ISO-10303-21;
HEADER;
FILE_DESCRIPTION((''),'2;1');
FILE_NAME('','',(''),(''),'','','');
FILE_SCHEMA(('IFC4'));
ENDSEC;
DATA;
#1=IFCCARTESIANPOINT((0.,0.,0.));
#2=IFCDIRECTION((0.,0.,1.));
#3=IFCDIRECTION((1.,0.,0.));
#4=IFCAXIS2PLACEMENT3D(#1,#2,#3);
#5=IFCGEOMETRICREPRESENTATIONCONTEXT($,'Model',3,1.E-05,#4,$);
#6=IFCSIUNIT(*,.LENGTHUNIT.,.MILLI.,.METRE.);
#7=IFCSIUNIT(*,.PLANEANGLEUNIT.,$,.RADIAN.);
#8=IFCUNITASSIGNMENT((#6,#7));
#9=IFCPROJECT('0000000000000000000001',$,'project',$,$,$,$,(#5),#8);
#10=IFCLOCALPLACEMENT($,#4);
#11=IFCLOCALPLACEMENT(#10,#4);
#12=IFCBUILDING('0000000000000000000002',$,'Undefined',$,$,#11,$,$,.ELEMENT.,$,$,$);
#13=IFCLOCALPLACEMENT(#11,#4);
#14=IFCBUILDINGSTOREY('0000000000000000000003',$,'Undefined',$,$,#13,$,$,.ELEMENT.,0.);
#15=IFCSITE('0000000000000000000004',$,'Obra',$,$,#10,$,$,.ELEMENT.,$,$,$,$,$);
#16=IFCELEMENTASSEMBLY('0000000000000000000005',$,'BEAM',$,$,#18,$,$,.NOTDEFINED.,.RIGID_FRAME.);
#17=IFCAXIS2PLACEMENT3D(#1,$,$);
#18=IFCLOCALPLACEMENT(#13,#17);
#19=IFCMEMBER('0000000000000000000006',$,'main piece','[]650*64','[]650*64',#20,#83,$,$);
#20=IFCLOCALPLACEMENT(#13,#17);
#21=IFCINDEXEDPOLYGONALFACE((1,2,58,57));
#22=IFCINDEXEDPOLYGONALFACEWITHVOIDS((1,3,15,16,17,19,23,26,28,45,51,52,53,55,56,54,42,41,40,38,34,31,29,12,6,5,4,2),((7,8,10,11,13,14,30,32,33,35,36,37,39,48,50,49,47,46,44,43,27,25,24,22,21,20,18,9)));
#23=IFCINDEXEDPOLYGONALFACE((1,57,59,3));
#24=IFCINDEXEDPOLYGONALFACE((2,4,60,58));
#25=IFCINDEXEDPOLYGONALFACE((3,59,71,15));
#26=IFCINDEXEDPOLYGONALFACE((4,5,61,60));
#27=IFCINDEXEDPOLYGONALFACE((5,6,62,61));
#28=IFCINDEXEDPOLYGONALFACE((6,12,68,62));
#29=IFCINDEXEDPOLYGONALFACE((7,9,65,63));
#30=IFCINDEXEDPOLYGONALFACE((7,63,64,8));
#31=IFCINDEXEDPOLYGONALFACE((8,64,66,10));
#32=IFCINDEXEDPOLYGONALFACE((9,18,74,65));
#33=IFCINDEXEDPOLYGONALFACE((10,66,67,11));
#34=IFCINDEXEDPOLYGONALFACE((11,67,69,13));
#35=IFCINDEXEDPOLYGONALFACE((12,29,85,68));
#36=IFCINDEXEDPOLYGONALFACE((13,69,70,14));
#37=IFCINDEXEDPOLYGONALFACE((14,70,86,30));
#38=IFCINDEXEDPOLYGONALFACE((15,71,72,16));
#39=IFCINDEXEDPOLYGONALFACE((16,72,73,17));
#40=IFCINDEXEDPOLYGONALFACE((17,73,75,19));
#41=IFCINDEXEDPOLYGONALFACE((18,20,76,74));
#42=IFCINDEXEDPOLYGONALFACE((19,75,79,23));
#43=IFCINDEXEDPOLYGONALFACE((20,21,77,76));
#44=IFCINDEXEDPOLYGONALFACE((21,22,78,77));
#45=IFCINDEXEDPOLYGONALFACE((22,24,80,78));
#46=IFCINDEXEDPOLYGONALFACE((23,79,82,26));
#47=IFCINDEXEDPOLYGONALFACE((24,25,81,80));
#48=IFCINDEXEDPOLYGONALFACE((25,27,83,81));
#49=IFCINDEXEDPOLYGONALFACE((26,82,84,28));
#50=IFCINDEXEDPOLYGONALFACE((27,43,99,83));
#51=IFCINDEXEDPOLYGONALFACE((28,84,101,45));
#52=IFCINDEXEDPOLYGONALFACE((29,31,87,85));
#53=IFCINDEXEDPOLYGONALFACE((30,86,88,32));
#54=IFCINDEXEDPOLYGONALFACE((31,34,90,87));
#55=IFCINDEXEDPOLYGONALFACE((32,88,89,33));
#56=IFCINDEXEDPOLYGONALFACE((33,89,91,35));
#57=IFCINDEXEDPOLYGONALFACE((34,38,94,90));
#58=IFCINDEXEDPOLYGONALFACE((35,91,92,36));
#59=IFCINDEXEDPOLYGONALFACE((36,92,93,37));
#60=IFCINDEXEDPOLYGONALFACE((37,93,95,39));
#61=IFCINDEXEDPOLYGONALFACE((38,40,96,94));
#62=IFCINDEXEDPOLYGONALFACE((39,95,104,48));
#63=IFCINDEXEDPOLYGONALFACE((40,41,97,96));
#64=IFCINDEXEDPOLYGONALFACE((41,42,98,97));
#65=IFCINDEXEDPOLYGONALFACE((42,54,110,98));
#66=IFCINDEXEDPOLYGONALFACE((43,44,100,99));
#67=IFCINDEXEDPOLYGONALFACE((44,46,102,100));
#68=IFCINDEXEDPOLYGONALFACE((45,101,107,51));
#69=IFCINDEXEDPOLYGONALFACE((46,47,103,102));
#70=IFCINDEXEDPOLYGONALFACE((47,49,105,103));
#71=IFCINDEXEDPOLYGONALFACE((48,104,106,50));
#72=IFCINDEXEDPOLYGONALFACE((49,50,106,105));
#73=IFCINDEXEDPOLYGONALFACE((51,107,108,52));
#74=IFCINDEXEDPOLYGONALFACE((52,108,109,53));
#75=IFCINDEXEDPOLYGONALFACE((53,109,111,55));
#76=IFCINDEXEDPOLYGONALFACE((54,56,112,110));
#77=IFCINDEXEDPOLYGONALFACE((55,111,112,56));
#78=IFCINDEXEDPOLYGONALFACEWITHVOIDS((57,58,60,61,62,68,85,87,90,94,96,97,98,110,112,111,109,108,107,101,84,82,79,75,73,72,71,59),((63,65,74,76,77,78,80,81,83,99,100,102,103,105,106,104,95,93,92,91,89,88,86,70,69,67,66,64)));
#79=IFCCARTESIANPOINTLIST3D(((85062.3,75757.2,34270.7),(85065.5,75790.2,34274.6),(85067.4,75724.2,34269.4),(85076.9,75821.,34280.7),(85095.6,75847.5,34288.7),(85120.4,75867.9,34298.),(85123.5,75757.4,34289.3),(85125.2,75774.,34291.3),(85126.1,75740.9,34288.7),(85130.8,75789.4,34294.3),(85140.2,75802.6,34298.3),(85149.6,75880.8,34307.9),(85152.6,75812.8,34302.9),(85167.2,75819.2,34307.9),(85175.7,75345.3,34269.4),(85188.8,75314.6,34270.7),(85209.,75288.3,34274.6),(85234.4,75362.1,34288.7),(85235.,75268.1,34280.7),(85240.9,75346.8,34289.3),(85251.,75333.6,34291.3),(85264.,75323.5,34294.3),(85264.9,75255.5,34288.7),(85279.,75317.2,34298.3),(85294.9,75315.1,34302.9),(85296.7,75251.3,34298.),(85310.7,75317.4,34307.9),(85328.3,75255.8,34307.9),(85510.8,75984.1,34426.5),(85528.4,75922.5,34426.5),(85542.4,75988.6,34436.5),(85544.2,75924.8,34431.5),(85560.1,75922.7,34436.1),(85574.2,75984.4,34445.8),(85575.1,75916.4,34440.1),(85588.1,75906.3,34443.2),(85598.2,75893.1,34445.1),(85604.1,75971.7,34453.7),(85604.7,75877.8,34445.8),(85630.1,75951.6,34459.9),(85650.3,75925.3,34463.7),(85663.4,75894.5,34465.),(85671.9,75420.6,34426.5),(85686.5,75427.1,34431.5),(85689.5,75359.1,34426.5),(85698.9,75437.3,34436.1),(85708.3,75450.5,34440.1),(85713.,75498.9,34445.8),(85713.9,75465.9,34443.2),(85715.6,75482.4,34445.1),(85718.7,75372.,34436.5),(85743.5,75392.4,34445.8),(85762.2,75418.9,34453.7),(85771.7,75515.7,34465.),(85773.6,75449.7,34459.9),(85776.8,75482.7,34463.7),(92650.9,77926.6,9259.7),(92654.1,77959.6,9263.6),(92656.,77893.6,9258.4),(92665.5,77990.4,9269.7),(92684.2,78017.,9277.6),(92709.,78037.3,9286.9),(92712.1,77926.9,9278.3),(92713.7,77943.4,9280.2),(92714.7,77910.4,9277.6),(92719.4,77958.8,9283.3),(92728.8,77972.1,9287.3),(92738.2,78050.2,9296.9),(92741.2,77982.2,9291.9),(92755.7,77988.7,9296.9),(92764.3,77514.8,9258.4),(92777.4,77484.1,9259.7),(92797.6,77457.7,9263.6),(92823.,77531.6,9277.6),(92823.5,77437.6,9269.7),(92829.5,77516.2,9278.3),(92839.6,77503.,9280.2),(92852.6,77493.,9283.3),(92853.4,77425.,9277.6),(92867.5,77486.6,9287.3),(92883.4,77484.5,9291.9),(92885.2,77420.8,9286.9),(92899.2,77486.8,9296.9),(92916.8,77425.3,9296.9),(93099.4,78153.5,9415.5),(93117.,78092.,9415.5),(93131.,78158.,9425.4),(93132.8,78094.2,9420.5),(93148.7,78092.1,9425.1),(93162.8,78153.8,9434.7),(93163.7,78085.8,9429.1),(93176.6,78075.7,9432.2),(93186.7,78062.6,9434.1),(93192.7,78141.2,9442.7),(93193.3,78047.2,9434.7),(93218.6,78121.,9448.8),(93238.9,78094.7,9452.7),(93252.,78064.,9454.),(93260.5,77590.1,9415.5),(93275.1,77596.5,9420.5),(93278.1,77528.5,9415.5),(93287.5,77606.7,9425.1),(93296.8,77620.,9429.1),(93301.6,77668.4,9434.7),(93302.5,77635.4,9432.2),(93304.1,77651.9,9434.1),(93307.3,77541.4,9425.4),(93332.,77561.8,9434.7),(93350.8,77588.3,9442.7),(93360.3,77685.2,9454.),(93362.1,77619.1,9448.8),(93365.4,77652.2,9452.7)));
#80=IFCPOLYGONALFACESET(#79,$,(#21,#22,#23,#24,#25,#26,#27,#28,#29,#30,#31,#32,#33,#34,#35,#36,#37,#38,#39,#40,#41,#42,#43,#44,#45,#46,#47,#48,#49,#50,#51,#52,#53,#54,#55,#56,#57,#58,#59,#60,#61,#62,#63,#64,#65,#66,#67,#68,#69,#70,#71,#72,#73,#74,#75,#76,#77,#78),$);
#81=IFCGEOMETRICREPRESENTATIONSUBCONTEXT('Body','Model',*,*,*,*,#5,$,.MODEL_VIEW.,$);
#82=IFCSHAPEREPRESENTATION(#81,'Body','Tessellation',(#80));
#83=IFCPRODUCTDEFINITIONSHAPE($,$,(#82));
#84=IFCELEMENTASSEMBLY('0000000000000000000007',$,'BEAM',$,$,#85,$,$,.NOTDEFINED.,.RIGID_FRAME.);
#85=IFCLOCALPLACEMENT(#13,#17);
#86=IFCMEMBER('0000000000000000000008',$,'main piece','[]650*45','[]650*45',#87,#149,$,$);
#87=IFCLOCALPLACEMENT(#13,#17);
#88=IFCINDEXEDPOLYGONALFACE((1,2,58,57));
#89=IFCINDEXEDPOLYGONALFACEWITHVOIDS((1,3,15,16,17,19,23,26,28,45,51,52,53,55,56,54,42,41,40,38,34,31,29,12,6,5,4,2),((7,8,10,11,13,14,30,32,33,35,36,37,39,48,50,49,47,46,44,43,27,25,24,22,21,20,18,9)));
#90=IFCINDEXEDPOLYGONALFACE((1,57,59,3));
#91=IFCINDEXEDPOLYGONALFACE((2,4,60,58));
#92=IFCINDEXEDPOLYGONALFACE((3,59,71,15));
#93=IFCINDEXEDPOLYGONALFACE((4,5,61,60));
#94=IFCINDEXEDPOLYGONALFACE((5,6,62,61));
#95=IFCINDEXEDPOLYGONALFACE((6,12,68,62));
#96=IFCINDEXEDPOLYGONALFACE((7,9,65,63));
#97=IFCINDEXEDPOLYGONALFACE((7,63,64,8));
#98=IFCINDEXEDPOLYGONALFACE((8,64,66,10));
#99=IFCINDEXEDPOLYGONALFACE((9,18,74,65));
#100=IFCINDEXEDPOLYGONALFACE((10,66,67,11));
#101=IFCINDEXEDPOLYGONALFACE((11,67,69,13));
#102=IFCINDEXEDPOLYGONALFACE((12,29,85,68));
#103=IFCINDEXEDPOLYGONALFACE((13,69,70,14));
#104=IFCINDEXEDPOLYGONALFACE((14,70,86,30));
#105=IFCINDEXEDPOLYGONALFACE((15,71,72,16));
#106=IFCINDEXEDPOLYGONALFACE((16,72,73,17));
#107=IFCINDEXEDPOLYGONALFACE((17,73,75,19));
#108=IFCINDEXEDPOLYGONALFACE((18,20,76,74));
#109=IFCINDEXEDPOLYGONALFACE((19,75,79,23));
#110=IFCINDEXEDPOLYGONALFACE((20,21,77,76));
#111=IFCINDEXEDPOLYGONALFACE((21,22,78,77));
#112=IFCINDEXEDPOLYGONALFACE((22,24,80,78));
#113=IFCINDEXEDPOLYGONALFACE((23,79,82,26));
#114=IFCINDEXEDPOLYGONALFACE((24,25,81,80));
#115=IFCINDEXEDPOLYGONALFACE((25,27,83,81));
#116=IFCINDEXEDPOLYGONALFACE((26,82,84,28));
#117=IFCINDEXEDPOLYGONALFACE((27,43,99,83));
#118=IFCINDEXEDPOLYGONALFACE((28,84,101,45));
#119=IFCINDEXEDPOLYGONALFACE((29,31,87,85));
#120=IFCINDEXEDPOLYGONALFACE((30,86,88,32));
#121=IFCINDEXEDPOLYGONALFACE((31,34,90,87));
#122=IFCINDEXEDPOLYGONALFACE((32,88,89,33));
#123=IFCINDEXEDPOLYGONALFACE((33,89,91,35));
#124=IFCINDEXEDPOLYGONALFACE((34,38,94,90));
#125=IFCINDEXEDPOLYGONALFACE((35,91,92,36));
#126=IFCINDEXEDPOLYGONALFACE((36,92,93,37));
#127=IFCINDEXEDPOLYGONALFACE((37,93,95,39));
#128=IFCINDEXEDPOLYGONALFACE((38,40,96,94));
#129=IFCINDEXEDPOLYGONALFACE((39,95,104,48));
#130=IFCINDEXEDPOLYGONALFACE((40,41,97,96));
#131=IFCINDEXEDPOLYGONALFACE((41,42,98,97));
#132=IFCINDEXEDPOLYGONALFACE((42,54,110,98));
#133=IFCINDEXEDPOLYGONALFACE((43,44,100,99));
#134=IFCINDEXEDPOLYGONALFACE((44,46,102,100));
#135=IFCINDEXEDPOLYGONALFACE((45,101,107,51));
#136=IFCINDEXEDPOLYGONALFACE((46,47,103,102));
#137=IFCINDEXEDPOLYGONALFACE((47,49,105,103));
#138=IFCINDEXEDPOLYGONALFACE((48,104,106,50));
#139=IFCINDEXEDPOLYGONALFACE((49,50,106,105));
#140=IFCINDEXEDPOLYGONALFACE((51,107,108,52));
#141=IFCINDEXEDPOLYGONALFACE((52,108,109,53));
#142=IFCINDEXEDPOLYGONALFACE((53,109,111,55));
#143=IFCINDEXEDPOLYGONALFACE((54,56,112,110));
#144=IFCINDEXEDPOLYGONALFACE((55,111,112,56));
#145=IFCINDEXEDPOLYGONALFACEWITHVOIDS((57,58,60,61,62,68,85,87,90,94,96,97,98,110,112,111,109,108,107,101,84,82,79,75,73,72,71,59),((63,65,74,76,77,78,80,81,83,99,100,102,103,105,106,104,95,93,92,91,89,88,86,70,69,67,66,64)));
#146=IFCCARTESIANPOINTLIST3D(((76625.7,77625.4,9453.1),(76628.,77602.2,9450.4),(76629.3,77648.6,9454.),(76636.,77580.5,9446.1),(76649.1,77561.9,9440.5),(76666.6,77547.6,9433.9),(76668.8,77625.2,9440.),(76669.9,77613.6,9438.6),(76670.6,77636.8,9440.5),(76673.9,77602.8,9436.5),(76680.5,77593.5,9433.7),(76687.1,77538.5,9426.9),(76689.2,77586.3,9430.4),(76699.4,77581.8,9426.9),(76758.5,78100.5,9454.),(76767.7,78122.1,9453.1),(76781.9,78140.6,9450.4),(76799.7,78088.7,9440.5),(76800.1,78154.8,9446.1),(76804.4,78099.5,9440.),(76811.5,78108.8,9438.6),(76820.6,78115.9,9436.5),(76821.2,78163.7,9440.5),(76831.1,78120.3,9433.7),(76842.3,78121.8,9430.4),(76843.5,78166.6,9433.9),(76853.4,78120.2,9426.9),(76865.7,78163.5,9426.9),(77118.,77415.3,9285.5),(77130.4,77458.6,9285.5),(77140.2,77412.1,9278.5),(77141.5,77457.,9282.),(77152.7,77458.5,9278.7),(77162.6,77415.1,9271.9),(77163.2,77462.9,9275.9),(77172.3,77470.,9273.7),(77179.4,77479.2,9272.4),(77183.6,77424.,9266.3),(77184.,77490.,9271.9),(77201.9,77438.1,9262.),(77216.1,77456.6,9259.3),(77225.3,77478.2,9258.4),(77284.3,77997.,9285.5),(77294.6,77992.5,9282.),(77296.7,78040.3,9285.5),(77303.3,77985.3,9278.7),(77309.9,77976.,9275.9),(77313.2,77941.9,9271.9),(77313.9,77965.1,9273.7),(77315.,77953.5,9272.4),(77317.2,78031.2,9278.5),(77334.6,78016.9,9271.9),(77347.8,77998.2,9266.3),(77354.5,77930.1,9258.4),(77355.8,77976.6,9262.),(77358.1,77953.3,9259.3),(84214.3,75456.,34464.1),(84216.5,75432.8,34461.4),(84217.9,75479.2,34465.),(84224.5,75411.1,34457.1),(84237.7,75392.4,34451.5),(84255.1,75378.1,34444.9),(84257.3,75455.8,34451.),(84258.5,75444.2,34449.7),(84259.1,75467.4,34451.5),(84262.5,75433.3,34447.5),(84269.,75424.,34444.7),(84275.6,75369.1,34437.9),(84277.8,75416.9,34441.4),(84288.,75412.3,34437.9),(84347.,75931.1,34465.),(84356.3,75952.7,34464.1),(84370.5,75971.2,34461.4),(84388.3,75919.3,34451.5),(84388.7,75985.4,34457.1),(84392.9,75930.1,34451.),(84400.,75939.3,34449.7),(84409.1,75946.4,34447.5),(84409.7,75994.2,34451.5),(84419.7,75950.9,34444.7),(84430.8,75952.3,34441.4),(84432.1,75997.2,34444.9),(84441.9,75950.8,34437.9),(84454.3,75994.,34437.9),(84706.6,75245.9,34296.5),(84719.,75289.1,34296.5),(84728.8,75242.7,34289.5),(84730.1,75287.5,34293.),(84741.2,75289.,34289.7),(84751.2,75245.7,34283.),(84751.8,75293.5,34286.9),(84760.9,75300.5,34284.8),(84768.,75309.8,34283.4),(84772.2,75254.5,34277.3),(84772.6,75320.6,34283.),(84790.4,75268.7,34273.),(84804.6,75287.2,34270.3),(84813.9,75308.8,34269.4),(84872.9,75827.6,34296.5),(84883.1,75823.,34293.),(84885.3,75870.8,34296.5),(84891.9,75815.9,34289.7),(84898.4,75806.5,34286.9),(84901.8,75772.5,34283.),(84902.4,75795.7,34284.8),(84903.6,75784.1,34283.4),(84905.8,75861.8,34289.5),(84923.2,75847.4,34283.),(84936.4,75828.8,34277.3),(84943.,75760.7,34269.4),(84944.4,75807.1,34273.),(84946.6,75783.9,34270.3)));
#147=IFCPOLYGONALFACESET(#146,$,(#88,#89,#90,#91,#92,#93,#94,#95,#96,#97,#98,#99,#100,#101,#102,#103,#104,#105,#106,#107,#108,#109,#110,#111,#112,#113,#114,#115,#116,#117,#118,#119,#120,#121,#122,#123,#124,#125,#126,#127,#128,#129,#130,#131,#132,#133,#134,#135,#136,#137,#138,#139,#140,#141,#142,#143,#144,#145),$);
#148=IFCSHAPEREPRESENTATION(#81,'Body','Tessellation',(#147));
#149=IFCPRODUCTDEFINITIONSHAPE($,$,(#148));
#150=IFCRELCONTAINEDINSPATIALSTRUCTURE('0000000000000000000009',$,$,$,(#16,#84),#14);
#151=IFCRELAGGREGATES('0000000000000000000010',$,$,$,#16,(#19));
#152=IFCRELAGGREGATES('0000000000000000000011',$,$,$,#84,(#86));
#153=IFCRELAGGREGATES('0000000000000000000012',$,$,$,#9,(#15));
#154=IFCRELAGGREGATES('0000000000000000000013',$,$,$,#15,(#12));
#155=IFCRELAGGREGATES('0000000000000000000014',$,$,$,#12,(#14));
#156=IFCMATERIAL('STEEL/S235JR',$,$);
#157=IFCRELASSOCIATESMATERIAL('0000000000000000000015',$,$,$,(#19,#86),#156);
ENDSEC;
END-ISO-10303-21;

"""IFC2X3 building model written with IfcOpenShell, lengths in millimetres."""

from ifc_helpers import new_model, si_unit, frame, origin_with_axes, origin_2d_with_axis, place, context, subcontext, project, spatial, hollow_rectangle, extrude, material, element, aggregate, save


model = new_model("IFC2X3")

# Units and contexts
model_context = context("Model", 3, precision=1e-05, world=origin_with_axes())
body_context = subcontext(model_context, "Body", "Model", "MODEL_VIEW")
ifc_project = project(units=[si_unit("LENGTHUNIT", "METRE", prefix="MILLI"), si_unit("PLANEANGLEUNIT", "RADIAN")], contexts=[model_context])

# Site, building, storey
site_placement = place(None, origin_with_axes())
site = spatial("IfcSite", under=ifc_project, at=site_placement, Name="Obra", CompositionType="ELEMENT")
building_placement = place(site_placement, origin_with_axes())
building = spatial("IfcBuilding", under=site, at=building_placement, Name="Undefined", CompositionType="ELEMENT")
storey_placement = place(building_placement, origin_with_axes())
storey = spatial("IfcBuildingStorey", under=building, at=storey_placement, Name="Undefined", CompositionType="ELEMENT", Elevation=0.0)

# Element assemblies, members
assembly_1_placement = place(storey_placement, origin_with_axes())
assembly_1 = element("IfcElementAssembly", 1, at=assembly_1_placement, inside=storey, Name="BEAM", AssemblyPlace="NOTDEFINED", PredefinedType="RIGID_FRAME")
ifc_material_1 = material(Name="STEEL/S235JR")
member_1_placement = place(assembly_1_placement, frame((93008.1, 77789.4, 9356.2), z_axis=(0.916911, 0.262129, 0.300936), x_axis=(-0.289344, -0.082718, 0.953644)))
member_1 = element("IfcMember", 2, at=member_1_placement, material=ifc_material_1, Name="main piece", Description="[]650*64", ObjectType="[]650*64", context=body_context, shape_type="SweptSolid", body=[
    extrude(hollow_rectangle(XDim=650.0, YDim=650.0, WallThickness=64.0, InnerFilletRadius=64.0, OuterFilletRadius=128.0, at=origin_2d_with_axis()), frame((26226.8, 0.0, 0.0), z_axis=(-1.0, 0.0, 0.0), x_axis=(0.0, -1.0, 0.0)), (0.0, 0.0, 1.0), 26226.8),
])
aggregate(assembly_1, [member_1])
assembly_2_placement = place(storey_placement, origin_with_axes())
assembly_2 = element("IfcElementAssembly", 3, at=assembly_2_placement, inside=storey, Name="BEAM", AssemblyPlace="NOTDEFINED", PredefinedType="RIGID_FRAME")
member_2_placement = place(assembly_2_placement, frame((76991.9, 77789.4, 9356.2), z_axis=(-0.916911, 0.262129, 0.300936), x_axis=(0.289344, -0.082718, 0.953644)))
member_2 = element("IfcMember", 4, at=member_2_placement, material=ifc_material_1, Name="main piece", Description="[]650*45", ObjectType="[]650*45", context=body_context, shape_type="SweptSolid", body=[
    extrude(hollow_rectangle(XDim=650.0, YDim=650.0, WallThickness=45.0, InnerFilletRadius=45.0, OuterFilletRadius=90.0, at=origin_2d_with_axis()), frame((26226.8, 0.0, 0.0), z_axis=(-1.0, 0.0, 0.0), x_axis=(0.0, -1.0, 0.0)), (0.0, 0.0, 1.0), 26226.8),
])
aggregate(assembly_2, [member_2])

save(model, "model.ifc")
